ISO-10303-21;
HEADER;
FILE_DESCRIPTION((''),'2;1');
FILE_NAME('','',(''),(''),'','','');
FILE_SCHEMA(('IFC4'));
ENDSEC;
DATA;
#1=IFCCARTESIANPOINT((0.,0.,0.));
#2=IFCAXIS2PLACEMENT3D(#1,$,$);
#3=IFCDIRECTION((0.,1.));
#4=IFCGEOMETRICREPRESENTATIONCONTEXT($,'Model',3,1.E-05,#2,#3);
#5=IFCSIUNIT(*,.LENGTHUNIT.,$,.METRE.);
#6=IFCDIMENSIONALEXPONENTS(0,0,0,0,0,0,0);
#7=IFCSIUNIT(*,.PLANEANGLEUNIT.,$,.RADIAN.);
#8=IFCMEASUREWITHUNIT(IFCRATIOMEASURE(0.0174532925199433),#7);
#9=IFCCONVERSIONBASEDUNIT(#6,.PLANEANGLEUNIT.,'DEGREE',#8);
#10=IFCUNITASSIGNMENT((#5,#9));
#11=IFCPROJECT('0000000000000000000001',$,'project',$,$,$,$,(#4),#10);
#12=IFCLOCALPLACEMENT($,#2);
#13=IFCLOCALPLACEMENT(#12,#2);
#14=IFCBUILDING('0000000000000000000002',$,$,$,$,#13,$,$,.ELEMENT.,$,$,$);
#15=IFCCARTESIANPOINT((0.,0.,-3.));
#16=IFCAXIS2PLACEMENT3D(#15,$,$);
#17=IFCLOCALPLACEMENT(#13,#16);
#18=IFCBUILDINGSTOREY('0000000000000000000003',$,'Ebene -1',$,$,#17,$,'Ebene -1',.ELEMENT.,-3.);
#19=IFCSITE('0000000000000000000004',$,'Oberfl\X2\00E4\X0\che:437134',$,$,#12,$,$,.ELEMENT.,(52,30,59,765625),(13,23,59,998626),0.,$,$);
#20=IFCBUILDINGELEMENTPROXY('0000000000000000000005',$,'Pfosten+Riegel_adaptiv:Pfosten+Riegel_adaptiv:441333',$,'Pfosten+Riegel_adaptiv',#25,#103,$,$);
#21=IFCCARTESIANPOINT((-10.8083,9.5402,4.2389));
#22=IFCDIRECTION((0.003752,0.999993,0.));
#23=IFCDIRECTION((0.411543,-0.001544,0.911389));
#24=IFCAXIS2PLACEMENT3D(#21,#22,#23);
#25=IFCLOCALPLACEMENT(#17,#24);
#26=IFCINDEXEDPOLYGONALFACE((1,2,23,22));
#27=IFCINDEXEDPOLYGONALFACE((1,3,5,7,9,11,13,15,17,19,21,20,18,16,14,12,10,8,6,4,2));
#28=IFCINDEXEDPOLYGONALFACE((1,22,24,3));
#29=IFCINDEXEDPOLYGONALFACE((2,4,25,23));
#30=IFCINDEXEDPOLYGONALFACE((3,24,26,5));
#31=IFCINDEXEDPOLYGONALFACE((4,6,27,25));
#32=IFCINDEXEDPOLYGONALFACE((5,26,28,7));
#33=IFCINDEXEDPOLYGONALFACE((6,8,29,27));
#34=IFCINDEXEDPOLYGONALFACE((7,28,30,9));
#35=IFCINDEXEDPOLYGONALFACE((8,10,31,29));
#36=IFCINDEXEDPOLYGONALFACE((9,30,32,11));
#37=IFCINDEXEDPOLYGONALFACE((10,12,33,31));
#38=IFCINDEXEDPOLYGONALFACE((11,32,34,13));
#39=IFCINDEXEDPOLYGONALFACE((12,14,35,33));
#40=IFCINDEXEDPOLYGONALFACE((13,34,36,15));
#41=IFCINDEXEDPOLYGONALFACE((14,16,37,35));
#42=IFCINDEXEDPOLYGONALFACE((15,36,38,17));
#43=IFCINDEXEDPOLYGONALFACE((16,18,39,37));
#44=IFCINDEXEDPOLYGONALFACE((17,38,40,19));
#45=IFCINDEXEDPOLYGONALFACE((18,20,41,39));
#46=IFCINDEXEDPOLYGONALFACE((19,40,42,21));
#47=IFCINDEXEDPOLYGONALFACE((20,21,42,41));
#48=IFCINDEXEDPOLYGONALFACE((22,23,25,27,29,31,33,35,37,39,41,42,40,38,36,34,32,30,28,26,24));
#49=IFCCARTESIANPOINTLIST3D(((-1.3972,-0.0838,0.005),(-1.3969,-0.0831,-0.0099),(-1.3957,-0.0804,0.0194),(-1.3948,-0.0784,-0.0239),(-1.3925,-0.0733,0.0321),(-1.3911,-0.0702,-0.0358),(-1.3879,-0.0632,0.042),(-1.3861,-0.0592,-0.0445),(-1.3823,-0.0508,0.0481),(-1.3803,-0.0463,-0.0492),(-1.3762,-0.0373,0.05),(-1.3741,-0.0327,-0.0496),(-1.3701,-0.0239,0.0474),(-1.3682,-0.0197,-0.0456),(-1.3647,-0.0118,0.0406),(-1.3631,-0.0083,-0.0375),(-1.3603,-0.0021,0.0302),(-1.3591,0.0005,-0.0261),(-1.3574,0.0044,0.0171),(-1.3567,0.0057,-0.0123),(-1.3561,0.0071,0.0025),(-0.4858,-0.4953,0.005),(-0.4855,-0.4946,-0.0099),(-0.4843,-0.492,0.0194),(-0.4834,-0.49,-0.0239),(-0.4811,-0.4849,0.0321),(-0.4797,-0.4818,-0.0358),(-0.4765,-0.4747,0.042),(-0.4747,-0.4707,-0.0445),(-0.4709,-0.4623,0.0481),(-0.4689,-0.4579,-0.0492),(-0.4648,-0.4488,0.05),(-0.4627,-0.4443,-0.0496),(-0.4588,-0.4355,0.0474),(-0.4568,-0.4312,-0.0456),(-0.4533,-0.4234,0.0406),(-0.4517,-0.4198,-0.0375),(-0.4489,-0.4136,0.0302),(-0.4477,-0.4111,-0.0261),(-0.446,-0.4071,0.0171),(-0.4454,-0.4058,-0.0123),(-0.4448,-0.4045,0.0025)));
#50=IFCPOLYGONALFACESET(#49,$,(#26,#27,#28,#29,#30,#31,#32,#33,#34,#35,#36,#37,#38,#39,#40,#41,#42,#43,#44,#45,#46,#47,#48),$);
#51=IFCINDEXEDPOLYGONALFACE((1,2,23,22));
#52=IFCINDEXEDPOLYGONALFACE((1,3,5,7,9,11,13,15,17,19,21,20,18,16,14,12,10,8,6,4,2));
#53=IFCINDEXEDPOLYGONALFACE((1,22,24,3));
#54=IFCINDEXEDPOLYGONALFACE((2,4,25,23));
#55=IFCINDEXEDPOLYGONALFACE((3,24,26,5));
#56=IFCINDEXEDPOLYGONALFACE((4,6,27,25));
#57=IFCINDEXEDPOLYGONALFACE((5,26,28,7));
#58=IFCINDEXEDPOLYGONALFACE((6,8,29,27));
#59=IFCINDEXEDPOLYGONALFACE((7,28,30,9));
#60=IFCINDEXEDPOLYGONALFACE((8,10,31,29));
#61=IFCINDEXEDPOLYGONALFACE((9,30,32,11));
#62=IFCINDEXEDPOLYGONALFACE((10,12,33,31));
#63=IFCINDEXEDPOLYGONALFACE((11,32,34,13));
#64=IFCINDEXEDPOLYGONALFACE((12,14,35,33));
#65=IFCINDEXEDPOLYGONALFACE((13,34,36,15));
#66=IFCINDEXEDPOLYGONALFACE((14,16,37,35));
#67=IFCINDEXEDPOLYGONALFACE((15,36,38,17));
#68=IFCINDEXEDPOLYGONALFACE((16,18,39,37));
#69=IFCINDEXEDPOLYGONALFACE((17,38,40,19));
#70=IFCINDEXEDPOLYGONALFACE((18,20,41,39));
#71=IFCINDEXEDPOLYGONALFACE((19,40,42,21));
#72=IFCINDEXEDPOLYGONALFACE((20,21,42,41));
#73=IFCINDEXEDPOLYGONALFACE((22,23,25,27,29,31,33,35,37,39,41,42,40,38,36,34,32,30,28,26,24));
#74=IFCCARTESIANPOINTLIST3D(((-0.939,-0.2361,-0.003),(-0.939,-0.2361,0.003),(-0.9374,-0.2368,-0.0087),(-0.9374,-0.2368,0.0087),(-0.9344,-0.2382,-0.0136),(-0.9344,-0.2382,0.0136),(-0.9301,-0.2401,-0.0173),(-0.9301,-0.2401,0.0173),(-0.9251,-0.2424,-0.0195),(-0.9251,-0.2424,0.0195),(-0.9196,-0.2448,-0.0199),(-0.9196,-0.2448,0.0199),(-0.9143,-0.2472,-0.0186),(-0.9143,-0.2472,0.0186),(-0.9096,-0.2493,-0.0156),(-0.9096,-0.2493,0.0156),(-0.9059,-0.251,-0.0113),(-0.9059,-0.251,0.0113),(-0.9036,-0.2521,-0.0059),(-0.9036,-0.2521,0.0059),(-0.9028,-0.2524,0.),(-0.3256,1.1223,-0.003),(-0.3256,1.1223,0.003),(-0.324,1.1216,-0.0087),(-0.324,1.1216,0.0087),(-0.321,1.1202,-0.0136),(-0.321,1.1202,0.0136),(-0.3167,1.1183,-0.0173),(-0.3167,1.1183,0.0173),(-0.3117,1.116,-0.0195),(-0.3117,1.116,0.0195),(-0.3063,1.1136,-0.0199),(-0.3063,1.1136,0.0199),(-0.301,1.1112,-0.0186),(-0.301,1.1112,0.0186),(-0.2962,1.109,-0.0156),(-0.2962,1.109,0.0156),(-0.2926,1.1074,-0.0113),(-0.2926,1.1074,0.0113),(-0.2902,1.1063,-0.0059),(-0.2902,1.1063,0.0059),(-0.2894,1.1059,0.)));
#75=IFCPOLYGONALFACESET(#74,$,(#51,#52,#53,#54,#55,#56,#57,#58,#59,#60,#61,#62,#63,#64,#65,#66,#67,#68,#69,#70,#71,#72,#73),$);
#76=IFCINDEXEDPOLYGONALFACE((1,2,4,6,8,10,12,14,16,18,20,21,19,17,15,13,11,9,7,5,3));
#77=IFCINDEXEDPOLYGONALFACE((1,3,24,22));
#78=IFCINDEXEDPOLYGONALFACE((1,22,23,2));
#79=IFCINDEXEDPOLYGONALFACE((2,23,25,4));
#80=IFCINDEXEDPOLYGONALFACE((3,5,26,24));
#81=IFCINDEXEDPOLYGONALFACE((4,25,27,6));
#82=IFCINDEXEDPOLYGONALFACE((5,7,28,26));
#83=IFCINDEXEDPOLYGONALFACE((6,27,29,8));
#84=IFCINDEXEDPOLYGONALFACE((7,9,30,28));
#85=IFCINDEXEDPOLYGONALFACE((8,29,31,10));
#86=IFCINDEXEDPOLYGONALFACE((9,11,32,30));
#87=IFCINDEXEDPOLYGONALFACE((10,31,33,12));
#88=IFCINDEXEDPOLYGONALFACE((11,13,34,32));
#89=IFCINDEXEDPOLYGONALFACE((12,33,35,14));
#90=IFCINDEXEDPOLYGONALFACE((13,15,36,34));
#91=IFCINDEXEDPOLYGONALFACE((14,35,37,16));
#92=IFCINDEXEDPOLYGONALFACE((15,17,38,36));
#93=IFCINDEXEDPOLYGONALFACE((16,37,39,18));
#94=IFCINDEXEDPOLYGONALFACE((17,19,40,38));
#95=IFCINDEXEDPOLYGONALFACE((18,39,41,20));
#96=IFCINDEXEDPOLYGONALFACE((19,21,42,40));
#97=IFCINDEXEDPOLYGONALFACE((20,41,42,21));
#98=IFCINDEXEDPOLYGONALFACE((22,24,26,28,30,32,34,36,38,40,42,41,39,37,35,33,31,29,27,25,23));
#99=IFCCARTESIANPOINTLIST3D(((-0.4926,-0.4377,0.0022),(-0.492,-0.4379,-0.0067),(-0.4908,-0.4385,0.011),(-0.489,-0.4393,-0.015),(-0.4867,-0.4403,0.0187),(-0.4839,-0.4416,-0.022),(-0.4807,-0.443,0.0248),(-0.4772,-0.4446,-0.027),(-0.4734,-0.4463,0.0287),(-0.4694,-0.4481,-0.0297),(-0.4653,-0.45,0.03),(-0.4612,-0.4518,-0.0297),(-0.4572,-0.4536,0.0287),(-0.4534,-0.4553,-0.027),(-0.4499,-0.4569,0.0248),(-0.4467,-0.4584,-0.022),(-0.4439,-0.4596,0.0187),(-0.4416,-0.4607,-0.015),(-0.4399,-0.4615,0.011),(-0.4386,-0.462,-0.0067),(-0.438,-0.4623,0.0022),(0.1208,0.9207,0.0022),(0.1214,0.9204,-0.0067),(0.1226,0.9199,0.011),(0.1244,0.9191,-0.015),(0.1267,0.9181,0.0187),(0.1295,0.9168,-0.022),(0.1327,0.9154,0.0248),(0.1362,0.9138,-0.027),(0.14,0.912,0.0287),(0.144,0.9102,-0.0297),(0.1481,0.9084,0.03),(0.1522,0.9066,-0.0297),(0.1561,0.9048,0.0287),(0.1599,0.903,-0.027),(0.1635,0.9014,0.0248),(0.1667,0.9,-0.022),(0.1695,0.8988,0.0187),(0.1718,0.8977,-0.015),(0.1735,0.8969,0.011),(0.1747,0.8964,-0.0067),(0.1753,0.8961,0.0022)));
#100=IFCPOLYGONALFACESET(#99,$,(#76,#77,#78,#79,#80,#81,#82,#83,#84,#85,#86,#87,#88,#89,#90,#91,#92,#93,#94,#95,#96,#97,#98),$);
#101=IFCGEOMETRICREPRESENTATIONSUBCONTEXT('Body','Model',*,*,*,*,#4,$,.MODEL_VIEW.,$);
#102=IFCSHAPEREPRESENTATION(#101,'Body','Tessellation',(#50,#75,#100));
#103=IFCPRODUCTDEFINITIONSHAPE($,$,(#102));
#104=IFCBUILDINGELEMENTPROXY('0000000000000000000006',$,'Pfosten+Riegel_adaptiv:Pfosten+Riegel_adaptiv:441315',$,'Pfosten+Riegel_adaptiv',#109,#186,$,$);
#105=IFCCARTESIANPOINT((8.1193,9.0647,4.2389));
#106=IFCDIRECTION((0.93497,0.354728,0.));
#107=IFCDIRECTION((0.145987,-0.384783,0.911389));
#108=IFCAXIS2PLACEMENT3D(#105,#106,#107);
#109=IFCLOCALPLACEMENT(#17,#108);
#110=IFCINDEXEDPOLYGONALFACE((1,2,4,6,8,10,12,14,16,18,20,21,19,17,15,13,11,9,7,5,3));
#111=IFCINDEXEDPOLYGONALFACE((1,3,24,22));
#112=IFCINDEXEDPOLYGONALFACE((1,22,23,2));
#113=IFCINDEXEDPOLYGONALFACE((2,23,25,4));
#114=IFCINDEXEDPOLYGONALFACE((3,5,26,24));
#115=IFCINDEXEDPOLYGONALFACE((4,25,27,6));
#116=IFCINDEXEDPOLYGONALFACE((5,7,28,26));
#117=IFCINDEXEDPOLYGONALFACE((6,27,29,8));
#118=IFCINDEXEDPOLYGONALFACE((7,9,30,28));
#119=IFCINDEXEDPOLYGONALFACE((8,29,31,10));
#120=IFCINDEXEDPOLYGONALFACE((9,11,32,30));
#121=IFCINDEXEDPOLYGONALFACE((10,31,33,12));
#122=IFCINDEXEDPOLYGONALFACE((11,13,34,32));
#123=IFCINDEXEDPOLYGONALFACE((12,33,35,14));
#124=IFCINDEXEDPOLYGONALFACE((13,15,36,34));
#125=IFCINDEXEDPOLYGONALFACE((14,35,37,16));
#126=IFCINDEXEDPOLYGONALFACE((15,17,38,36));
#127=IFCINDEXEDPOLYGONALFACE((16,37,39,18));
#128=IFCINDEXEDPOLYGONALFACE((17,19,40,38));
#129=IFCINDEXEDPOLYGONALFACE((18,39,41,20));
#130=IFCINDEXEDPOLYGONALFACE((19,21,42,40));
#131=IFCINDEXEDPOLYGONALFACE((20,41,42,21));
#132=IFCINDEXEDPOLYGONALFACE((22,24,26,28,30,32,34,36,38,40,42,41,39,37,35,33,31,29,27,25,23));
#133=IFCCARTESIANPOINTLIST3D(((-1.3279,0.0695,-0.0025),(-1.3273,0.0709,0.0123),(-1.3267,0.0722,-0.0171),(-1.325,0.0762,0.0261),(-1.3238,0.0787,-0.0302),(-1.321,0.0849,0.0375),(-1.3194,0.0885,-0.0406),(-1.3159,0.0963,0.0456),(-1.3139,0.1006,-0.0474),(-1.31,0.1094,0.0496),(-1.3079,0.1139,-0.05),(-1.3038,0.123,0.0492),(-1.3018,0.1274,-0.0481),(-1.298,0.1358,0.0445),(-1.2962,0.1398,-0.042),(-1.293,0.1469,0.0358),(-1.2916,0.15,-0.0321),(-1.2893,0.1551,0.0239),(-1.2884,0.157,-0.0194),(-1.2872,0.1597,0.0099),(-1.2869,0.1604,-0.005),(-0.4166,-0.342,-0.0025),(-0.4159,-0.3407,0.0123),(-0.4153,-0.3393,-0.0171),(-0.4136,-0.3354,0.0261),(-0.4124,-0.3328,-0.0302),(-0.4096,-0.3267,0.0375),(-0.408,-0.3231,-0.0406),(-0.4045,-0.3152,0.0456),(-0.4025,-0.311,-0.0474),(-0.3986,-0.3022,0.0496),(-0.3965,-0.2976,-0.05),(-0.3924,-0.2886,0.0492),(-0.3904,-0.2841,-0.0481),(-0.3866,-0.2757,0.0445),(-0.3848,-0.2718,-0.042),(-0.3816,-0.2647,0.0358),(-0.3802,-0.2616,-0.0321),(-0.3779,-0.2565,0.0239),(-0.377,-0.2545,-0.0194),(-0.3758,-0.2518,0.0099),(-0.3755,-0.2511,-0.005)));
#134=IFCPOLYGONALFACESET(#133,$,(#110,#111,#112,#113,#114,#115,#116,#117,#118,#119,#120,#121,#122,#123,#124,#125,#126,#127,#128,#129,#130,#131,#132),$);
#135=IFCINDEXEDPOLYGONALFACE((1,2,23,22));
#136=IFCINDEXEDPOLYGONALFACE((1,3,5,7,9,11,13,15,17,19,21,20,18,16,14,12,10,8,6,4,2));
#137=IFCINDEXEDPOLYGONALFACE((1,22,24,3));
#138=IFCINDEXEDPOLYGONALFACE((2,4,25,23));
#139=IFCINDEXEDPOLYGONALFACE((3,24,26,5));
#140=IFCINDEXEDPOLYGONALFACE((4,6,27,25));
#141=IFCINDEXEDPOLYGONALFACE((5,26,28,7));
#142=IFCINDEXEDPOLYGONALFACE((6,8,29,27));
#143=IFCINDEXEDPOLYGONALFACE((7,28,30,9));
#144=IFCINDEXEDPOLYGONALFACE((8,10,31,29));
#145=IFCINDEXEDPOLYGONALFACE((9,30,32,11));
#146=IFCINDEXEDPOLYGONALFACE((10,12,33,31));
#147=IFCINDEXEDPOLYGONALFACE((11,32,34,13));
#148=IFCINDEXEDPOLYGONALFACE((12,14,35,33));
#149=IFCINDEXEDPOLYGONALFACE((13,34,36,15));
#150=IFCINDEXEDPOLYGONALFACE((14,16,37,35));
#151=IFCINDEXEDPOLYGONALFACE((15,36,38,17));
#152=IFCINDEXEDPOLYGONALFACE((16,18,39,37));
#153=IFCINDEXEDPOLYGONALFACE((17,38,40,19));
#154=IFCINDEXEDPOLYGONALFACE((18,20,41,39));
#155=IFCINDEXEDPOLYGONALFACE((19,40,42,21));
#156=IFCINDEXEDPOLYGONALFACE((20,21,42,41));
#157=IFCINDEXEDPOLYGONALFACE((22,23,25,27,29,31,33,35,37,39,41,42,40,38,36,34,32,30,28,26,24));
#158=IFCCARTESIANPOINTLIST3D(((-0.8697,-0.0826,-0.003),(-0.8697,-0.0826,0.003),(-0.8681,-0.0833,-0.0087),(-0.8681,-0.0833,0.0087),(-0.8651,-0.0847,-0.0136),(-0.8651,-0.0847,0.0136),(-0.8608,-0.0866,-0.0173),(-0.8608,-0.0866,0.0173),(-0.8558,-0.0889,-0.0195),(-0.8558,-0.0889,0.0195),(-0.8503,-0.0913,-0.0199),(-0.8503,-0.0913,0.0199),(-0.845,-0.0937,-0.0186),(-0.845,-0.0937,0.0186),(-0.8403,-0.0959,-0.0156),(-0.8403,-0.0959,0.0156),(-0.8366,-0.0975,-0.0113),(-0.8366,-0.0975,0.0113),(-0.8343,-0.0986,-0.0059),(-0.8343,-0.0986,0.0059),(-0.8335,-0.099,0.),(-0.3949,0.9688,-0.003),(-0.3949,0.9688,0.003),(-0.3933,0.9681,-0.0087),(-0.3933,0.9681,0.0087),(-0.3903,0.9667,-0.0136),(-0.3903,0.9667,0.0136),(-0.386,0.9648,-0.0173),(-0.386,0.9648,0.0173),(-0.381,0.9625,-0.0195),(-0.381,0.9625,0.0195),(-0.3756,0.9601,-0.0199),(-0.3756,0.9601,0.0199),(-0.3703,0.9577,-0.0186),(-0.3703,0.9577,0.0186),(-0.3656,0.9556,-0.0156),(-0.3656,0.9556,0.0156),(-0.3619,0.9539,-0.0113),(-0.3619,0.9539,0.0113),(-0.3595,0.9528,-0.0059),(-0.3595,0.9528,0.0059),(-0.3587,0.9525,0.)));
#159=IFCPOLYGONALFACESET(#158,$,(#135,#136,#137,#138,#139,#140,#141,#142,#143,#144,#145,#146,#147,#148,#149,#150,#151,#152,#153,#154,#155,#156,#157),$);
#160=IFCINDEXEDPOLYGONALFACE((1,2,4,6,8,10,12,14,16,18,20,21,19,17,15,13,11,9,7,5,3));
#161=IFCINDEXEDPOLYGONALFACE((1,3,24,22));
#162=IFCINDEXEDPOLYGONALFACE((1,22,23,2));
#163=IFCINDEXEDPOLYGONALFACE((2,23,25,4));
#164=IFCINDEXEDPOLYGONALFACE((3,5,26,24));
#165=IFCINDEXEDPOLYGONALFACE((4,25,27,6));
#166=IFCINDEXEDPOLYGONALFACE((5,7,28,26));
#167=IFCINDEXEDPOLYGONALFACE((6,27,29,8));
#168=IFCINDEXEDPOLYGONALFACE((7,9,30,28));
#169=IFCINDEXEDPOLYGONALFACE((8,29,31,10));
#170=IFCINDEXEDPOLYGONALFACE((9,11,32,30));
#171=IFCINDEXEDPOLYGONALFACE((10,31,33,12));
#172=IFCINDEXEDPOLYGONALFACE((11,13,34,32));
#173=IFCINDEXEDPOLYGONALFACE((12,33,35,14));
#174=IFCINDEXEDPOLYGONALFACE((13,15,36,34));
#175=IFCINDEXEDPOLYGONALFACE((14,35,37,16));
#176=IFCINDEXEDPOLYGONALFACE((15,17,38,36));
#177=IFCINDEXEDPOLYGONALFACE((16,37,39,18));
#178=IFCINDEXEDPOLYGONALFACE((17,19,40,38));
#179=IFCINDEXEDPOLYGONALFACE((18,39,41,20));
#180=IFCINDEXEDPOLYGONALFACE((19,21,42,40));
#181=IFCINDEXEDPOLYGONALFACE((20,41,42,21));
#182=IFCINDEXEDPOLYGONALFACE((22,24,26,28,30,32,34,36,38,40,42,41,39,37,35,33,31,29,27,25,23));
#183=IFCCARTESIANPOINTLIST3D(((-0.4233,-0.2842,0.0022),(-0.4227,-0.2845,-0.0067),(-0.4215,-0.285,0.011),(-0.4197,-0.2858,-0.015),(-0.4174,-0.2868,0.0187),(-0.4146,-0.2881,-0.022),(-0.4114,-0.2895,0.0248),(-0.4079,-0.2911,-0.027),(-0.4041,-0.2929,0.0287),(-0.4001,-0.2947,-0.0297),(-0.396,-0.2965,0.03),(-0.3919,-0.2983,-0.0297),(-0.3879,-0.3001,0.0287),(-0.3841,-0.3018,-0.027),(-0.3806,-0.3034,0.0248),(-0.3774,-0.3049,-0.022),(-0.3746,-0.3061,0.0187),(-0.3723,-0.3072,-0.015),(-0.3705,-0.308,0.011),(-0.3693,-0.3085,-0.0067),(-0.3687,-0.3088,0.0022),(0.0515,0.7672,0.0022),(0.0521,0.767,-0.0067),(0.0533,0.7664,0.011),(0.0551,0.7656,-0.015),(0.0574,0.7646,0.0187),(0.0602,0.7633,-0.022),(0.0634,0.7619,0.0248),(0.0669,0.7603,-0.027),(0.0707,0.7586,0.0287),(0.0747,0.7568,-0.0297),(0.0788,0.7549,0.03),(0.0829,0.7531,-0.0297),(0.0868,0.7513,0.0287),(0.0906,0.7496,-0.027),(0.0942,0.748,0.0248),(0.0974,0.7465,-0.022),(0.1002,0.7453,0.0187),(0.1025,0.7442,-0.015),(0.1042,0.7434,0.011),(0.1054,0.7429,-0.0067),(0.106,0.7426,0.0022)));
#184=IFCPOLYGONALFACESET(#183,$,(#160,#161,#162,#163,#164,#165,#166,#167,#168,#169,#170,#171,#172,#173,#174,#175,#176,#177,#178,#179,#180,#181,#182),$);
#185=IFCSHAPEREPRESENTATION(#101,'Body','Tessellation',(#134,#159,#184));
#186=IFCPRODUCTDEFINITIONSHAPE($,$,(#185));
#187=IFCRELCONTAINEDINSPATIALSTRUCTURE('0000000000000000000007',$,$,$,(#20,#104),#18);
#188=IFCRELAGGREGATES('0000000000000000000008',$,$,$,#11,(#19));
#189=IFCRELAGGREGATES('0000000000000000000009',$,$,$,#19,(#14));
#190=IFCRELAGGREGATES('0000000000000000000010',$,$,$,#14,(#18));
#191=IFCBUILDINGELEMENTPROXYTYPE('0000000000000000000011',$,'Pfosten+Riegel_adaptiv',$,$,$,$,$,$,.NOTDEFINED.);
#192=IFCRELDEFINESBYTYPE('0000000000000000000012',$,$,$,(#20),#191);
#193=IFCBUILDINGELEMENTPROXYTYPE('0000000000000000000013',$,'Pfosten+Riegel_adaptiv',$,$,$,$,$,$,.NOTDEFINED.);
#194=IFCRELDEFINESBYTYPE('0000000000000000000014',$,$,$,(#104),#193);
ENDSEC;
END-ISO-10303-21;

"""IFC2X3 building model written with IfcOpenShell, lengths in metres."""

from ifc_helpers import new_model, entity, si_unit, converted_unit, direction, frame, frame_2d, origin, place, context, subcontext, project, spatial, circle, extrude, source, transform, mapped, type_object, type_shapes, element, save


model = new_model("IFC2X3")

# Units and contexts
model_context = context("Model", 3, precision=1e-05, world=origin(), true_north=direction((0.0, 1.0)))
body_context = subcontext(model_context, "Body", "Model", "MODEL_VIEW")
ifc_project = project(units=[si_unit("LENGTHUNIT", "METRE"), converted_unit("PLANEANGLEUNIT", "DEGREE", entity("IfcRatioMeasure", 0.0174532925199433), si_unit("PLANEANGLEUNIT", "RADIAN"), dimensions=[0, 0, 0, 0, 0, 0, 0])], contexts=[model_context])

# Site, building, storey
site_placement = place(None, origin())
site = spatial("IfcSite", under=ifc_project, at=site_placement, Name="Oberfläche:437134", CompositionType="ELEMENT", RefLatitude=(52, 30, 59, 765625), RefLongitude=(13, 23, 59, 998626), RefElevation=0.0)
building_placement = place(site_placement, origin())
building = spatial("IfcBuilding", under=site, at=building_placement, CompositionType="ELEMENT")
storey_placement = place(building_placement, frame((0.0, 0.0, -3.0)))
storey = spatial("IfcBuildingStorey", under=building, at=storey_placement, Name="Ebene -1", LongName="Ebene -1", CompositionType="ELEMENT", Elevation=-3.0)

# Building element proxies
building_element_proxy_type_1 = type_object("IfcBuildingElementProxyType", Name="Pfosten+Riegel_adaptiv", PredefinedType="NOTDEFINED")
shared_shape_1 = source(origin(), body_context, "Body", "SweptSolid", [
    extrude(circle(Radius=0.05, at=frame_2d((0.0, 0.0), x_axis=(1.0, 0.0))), frame((-0.4653, -0.45, 0.0), z_axis=(-0.911389, 0.411546, 0.0), x_axis=(0.16937, 0.375078, -0.911389)), (0.0, 0.0, 1.0), 1.0),
    extrude(circle(Radius=0.02, at=frame_2d((0.0, 0.0), x_axis=(1.0, 0.0))), frame((-0.921, -0.2442, 0.0), z_axis=(0.411546, 0.911389, 0.0), x_axis=(0.911389, -0.411546, 0.0)), (0.0, 0.0, 1.0), 1.4904),
    extrude(circle(Radius=0.03, at=frame_2d((0.0, 0.0), x_axis=(1.0, 0.0))), frame((-0.4653, -0.45, 0.0), z_axis=(0.411546, 0.911389, 0.0), x_axis=(0.0, 0.0, 1.0)), (0.0, 0.0, 1.0), 1.4904),
])
type_shapes(building_element_proxy_type_1, [shared_shape_1])
for number, where, z_axis, x_axis, name in (
    (1, (-10.8083, 9.5402, 4.2389), (0.003752, 0.999993, 0.0), (0.411543, -0.001544, 0.911389), "Pfosten+Riegel_adaptiv:Pfosten+Riegel_adaptiv:441333"),
):
    element("IfcBuildingElementProxy", number, at=place(storey_placement, frame(where, z_axis=z_axis, x_axis=x_axis)), inside=storey, type_object=building_element_proxy_type_1, Name=name, ObjectType="Pfosten+Riegel_adaptiv", context=body_context, shape_type="MappedRepresentation", body=[
        mapped(shared_shape_1, transform((0.0, 0.0, 0.0), scale=1.0)),
    ])
building_element_proxy_type_2 = type_object("IfcBuildingElementProxyType", Name="Pfosten+Riegel_adaptiv", PredefinedType="NOTDEFINED")
shared_shape_2 = source(origin(), body_context, "Body", "SweptSolid", [
    extrude(circle(Radius=0.05, at=frame_2d((0.0, 0.0), x_axis=(1.0, 0.0))), frame((-1.3074, 0.1151, 0.0), z_axis=(0.911389, -0.411546, 0.0), x_axis=(-0.16937, -0.375078, 0.911389)), (0.0, 0.0, 1.0), 1.0),
    extrude(circle(Radius=0.02, at=frame_2d((0.0, 0.0), x_axis=(1.0, 0.0))), frame((-0.8517, -0.0907, 0.0), z_axis=(0.411546, 0.911389, 0.0), x_axis=(0.911389, -0.411546, 0.0)), (0.0, 0.0, 1.0), 1.1536),
    extrude(circle(Radius=0.03, at=frame_2d((0.0, 0.0), x_axis=(1.0, 0.0))), frame((-0.396, -0.2965, 0.0), z_axis=(0.411546, 0.911389, 0.0), x_axis=(0.0, 0.0, 1.0)), (0.0, 0.0, 1.0), 1.1536),
])
type_shapes(building_element_proxy_type_2, [shared_shape_2])
proxy_1_placement = place(storey_placement, frame((8.1193, 9.0647, 4.2389), z_axis=(0.93497, 0.354728, 0.0), x_axis=(0.145987, -0.384783, 0.911389)))
element("IfcBuildingElementProxy", 2, at=proxy_1_placement, inside=storey, type_object=building_element_proxy_type_2, Name="Pfosten+Riegel_adaptiv:Pfosten+Riegel_adaptiv:441315", ObjectType="Pfosten+Riegel_adaptiv", context=body_context, shape_type="MappedRepresentation", body=[
    mapped(shared_shape_2, transform((0.0, 0.0, 0.0), scale=1.0)),
])

save(model, "model.ifc")
